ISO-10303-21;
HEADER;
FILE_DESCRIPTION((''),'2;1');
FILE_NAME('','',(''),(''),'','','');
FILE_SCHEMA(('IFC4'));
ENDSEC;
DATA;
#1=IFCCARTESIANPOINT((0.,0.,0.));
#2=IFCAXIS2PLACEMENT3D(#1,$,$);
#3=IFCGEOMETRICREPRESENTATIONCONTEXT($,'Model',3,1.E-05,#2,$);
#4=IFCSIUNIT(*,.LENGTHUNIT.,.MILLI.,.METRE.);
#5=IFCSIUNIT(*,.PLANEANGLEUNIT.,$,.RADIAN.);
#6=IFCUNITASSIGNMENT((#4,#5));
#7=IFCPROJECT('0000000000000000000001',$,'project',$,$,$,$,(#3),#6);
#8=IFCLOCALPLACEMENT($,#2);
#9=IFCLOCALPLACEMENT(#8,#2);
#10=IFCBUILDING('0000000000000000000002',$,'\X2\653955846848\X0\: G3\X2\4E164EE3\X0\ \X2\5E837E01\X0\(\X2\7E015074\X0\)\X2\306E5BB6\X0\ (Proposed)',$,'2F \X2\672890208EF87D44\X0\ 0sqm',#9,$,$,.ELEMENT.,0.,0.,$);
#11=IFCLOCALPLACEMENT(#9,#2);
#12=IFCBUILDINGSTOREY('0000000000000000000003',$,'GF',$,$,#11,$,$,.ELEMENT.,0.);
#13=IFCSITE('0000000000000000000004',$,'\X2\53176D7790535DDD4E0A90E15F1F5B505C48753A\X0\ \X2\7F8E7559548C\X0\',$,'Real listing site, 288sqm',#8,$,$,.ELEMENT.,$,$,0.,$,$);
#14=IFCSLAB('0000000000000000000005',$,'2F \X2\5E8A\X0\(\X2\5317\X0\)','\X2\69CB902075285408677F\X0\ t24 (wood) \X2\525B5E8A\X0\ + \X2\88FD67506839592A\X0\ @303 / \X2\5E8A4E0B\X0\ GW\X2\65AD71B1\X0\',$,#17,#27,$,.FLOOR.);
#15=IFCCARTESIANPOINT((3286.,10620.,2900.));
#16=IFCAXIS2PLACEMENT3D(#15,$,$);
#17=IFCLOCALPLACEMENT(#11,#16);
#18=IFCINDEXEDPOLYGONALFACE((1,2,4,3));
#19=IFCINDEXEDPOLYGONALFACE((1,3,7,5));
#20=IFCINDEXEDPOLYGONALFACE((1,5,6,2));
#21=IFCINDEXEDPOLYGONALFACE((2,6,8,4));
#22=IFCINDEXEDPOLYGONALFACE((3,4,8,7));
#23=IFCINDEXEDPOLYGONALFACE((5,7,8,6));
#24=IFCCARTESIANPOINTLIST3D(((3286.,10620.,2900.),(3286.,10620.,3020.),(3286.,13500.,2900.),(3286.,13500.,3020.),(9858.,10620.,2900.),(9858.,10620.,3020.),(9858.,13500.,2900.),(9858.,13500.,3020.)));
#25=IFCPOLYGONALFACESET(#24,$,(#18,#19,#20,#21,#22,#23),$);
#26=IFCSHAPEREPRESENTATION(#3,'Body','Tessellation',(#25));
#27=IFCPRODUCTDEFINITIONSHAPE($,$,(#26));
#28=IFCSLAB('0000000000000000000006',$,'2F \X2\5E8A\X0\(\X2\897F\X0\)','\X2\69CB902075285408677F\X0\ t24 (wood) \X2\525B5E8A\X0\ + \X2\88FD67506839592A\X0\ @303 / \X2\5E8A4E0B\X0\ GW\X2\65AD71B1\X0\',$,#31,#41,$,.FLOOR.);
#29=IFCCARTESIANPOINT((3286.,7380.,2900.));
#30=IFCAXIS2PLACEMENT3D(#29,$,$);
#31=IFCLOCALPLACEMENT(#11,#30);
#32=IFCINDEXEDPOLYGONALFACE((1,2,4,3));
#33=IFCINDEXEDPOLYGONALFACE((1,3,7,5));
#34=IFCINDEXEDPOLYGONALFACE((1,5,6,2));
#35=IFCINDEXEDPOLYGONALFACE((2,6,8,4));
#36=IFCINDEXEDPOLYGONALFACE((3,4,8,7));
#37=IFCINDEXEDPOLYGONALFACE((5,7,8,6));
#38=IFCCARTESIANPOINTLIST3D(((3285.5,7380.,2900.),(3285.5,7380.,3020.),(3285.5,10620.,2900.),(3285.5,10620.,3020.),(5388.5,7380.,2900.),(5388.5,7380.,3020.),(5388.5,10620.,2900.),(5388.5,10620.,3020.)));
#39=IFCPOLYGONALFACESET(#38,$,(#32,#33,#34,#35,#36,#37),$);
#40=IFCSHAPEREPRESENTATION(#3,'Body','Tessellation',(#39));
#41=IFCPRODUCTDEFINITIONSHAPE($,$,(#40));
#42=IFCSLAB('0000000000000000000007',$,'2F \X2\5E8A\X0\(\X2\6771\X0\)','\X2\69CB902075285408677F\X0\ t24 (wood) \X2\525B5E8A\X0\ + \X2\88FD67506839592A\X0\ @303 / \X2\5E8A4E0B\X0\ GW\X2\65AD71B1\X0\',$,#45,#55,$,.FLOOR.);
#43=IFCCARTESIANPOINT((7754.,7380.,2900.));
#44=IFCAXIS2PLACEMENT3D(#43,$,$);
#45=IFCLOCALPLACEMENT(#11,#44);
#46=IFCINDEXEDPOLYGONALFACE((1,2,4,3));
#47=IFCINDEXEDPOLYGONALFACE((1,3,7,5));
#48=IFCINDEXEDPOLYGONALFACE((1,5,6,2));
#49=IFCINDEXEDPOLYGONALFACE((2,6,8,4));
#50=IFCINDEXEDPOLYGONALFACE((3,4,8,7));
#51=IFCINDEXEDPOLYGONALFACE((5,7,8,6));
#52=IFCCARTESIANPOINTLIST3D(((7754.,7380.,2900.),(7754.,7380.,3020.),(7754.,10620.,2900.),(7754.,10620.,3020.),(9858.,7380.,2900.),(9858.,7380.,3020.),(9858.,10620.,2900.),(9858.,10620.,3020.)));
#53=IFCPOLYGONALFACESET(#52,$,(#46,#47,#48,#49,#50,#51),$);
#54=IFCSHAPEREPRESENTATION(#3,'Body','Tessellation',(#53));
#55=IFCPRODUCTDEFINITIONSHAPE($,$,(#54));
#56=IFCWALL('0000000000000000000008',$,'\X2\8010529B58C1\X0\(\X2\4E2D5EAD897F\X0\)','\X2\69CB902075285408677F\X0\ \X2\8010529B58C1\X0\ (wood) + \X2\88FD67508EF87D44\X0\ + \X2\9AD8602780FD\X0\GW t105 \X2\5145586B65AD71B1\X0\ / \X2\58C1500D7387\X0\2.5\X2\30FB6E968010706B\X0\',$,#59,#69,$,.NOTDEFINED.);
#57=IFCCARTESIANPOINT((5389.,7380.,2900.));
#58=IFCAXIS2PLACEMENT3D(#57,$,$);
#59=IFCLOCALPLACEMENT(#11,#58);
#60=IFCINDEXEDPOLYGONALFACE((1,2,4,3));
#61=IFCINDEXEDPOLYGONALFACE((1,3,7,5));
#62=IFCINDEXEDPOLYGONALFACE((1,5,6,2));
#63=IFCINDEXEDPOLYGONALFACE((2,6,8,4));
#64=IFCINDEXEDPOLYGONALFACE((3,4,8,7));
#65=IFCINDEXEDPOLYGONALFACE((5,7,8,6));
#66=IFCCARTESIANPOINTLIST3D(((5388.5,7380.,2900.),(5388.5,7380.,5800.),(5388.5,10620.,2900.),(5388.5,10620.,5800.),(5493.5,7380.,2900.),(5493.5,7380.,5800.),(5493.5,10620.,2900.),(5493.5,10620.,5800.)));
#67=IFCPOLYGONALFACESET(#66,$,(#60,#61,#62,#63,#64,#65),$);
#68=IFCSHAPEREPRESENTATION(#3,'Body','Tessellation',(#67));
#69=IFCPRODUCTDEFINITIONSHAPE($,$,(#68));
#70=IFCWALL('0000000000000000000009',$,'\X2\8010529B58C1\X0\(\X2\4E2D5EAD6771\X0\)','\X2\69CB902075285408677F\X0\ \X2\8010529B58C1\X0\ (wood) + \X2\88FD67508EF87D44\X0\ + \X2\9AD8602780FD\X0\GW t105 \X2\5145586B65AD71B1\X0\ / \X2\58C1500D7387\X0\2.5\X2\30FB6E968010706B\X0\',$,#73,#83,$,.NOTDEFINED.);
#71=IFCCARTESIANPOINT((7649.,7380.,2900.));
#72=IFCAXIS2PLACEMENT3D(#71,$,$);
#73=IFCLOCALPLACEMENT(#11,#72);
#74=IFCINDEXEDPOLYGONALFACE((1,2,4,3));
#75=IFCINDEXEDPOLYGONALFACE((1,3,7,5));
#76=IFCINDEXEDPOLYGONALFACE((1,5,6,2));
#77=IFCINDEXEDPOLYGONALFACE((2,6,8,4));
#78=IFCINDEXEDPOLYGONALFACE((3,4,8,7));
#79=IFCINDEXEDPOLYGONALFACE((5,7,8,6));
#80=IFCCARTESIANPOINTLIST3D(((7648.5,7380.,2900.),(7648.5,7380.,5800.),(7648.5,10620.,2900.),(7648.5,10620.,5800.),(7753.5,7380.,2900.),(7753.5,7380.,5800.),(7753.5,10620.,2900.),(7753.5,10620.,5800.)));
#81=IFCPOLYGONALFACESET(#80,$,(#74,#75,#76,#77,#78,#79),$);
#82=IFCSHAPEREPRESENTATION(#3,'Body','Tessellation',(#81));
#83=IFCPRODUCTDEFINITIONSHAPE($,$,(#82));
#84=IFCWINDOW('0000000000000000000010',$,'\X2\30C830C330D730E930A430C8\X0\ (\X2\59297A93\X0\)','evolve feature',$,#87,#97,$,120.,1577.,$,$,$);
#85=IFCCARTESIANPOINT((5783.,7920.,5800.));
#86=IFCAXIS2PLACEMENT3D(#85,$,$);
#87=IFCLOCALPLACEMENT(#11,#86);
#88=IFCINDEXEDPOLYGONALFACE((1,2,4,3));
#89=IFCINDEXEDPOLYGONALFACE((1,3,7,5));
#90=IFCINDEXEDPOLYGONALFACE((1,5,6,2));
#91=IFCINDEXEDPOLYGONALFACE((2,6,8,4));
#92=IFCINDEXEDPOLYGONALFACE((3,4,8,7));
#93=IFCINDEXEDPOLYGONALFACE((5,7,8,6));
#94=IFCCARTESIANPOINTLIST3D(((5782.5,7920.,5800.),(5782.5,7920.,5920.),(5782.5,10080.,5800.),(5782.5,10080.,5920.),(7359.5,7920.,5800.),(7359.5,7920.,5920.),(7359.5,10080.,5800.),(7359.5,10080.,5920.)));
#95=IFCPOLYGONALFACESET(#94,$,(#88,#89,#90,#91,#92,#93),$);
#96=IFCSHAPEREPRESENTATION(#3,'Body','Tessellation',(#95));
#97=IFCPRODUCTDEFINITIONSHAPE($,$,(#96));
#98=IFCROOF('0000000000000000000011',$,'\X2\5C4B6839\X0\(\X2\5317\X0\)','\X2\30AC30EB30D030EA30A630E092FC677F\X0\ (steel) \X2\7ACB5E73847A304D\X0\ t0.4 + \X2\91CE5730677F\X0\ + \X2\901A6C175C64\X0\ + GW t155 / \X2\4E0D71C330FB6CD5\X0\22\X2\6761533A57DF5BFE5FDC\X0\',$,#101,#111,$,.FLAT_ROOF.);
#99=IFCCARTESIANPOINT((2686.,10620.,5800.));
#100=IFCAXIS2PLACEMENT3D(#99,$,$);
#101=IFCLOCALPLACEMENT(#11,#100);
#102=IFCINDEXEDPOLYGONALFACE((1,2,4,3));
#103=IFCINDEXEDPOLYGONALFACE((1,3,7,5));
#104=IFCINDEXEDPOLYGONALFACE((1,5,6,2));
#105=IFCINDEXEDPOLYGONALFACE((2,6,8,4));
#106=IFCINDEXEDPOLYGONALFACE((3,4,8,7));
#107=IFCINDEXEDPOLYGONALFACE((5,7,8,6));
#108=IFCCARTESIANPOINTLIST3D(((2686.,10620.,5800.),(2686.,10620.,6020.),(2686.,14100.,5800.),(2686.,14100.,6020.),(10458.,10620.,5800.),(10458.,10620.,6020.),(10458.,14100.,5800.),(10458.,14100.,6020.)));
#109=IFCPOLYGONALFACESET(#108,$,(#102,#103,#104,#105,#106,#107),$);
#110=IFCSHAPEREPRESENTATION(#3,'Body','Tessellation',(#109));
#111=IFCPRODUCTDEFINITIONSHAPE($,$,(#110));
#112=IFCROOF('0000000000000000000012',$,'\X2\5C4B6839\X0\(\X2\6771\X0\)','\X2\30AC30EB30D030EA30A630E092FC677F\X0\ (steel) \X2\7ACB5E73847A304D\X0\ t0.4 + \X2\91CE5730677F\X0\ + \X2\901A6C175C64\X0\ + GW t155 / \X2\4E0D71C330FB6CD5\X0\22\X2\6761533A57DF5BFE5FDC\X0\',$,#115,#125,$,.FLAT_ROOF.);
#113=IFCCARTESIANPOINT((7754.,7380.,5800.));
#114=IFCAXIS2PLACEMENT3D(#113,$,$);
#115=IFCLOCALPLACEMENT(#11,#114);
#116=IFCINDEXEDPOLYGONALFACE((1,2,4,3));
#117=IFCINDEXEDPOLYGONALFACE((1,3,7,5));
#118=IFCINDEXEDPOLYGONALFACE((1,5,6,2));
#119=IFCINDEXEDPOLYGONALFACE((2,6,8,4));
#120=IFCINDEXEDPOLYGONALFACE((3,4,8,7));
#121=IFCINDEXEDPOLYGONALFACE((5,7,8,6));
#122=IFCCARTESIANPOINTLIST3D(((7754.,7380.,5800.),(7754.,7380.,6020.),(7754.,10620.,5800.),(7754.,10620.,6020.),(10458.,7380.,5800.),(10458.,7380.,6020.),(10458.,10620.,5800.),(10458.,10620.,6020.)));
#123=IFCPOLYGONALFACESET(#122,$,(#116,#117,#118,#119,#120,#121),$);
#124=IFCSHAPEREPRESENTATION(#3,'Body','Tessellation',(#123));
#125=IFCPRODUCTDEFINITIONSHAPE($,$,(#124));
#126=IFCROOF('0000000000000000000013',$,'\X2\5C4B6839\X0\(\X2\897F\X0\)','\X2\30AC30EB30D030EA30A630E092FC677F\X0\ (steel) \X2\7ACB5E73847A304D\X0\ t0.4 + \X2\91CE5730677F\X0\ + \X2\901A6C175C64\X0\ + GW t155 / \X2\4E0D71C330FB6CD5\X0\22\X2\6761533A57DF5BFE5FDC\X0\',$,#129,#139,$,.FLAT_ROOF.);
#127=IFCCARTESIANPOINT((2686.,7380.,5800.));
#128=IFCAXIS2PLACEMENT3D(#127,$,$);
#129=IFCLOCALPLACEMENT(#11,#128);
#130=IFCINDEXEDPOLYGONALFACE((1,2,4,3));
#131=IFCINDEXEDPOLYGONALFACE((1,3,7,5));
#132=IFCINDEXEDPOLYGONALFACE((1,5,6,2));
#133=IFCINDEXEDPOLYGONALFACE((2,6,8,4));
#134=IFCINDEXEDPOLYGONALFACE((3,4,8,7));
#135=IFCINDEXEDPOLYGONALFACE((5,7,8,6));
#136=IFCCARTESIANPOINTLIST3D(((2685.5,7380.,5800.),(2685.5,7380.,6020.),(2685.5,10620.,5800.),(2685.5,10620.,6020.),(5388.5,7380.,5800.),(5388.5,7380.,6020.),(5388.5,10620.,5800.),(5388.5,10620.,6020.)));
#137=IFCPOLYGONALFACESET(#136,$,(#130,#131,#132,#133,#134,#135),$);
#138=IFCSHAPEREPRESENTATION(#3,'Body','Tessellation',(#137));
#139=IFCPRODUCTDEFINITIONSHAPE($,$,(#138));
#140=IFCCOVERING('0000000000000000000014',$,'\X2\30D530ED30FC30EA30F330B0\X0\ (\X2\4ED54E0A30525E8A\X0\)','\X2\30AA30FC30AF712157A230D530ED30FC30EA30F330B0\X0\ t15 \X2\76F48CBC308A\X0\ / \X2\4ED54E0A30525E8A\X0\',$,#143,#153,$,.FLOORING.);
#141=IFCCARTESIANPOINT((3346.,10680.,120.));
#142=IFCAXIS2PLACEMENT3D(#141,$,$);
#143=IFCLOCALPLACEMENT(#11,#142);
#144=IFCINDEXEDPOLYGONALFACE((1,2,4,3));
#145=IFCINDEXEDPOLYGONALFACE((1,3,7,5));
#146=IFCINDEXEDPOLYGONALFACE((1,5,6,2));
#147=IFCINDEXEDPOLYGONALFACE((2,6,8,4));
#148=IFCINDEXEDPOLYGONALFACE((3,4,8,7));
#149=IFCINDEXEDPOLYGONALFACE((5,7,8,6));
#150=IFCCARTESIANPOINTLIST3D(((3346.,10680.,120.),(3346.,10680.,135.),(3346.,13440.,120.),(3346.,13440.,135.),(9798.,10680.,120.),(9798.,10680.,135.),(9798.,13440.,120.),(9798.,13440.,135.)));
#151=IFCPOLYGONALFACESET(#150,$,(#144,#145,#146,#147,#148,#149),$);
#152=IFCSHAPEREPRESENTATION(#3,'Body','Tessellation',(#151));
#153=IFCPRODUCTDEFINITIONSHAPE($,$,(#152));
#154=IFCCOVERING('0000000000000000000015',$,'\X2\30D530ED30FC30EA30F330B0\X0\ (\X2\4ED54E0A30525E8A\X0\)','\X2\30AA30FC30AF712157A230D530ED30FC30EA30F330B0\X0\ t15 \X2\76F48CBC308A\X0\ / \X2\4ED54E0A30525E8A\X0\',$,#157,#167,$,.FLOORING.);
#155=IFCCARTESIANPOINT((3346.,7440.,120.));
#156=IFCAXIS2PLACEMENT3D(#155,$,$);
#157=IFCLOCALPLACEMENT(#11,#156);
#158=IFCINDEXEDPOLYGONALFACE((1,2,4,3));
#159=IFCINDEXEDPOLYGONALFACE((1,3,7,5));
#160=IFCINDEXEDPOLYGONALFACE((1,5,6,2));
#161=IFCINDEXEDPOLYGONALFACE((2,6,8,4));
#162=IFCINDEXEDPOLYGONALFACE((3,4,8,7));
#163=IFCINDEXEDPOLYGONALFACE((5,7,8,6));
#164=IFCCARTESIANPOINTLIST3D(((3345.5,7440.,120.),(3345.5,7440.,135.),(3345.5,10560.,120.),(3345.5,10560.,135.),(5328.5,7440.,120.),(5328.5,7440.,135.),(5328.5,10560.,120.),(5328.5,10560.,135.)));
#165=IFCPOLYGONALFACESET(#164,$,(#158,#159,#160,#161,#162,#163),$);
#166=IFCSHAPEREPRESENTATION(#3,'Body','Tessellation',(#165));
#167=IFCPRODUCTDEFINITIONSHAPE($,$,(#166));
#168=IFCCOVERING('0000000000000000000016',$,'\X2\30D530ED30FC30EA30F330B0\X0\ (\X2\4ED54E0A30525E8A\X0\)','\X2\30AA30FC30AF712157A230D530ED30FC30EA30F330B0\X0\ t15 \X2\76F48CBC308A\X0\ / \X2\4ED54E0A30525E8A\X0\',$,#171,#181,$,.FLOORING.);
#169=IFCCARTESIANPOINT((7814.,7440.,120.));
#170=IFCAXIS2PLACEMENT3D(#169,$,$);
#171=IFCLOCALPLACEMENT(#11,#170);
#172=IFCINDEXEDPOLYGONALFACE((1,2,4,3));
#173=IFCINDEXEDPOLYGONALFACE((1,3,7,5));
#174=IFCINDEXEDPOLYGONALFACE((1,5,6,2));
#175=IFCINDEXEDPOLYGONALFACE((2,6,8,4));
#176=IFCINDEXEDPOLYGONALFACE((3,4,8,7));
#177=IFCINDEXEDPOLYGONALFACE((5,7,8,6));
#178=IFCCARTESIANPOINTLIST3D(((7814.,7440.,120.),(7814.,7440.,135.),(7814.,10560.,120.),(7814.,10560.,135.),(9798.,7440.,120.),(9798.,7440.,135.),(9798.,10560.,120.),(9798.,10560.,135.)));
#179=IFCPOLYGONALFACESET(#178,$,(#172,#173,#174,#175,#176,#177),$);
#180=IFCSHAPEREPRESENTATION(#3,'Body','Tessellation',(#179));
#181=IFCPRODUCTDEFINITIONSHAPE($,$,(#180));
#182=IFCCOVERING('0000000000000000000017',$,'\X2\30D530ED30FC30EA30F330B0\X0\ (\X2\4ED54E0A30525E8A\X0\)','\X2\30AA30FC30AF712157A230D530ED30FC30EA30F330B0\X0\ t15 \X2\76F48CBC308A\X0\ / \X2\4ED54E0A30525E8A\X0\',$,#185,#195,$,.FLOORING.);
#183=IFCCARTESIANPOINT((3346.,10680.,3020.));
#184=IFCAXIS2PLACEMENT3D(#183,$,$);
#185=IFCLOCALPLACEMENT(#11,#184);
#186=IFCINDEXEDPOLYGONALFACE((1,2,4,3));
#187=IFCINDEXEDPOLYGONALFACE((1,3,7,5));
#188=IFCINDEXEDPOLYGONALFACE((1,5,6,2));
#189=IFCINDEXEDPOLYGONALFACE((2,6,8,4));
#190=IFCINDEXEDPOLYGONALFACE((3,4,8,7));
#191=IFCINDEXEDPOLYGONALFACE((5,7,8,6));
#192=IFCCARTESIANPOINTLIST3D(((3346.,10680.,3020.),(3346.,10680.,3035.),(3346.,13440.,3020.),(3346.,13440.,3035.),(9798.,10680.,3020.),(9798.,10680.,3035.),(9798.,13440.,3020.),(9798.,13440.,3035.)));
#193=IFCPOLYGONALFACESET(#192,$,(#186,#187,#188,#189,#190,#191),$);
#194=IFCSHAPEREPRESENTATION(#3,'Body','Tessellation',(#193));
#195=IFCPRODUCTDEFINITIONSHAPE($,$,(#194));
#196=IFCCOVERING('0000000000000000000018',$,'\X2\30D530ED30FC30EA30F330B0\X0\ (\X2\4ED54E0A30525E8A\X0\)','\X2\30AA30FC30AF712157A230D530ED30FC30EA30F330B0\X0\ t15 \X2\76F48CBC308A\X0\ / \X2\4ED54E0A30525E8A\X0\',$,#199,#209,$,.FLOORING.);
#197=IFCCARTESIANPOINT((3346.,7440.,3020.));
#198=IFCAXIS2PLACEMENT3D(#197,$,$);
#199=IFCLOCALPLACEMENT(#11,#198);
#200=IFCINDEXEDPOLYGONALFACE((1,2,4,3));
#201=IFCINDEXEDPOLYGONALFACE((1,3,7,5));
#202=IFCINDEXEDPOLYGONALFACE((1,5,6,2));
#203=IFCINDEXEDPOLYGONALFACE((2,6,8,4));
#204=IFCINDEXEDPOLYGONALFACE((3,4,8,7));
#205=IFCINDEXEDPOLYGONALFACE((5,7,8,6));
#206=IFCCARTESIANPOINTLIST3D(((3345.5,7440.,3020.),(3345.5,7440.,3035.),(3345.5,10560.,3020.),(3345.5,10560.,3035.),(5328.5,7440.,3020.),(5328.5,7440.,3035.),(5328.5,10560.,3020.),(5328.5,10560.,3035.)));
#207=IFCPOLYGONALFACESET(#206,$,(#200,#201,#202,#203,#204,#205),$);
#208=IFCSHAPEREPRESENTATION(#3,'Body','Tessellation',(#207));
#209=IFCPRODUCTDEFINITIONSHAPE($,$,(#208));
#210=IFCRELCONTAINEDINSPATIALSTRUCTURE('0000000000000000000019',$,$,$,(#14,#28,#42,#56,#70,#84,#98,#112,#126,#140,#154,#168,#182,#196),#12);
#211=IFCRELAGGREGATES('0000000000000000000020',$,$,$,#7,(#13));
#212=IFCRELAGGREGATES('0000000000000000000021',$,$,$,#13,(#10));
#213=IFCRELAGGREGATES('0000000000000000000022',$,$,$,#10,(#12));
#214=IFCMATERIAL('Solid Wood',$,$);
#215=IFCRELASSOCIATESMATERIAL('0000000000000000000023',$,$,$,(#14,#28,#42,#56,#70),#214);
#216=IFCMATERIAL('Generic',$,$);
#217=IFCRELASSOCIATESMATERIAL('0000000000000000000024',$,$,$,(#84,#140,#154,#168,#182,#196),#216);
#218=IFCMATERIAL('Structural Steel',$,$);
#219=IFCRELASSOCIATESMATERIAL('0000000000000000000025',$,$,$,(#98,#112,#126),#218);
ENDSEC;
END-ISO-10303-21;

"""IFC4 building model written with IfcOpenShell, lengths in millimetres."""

from ifc_helpers import new_model, si_unit, frame, frame_2d, origin, place, context, project, spatial, rectangle, extrude, material, element, save


model = new_model("IFC4")

# Units and contexts
model_context = context("Model", 3, precision=1e-05, world=origin())
ifc_project = project(units=[si_unit("LENGTHUNIT", "METRE", prefix="MILLI"), si_unit("PLANEANGLEUNIT", "RADIAN")], contexts=[model_context])

# Site, building, storey
site_placement = place(None, origin())
site = spatial("IfcSite", under=ifc_project, at=site_placement, Name="北海道川上郡弟子屈町 美留和", ObjectType="Real listing site, 288sqm", CompositionType="ELEMENT", RefElevation=0.0)
building_placement = place(site_placement, origin())
building = spatial("IfcBuilding", under=site, at=building_placement, Name="改善案: G3世代 広縁(縁側)の家 (Proposed)", ObjectType="2F 木造軸組 0sqm", CompositionType="ELEMENT", ElevationOfRefHeight=0.0, ElevationOfTerrain=0.0)
storey_placement = place(building_placement, origin())
storey = spatial("IfcBuildingStorey", under=building, at=storey_placement, Name="GF", CompositionType="ELEMENT", Elevation=0.0)

# Slabs
ifc_material_1 = material(Name="Solid Wood")
slab_1_placement = place(storey_placement, frame((3286.0, 10620.0, 2900.0)))
element("IfcSlab", 1, at=slab_1_placement, inside=storey, material=ifc_material_1, Name="2F 床(北)", Description="構造用合板 t24 (wood) 剛床 + 製材根太 @303 / 床下 GW断熱", PredefinedType="FLOOR", context=model_context, shape_type="SweptSolid", body=[
    extrude(rectangle(XDim=6572.0, YDim=2880.0, at=frame_2d((3286.0, 1440.0))), frame((3286.0, 10620.0, 2900.0)), (0.0, 0.0, 1.0), 120.0),
])
slab_2_placement = place(storey_placement, frame((3286.0, 7380.0, 2900.0)))
element("IfcSlab", 2, at=slab_2_placement, inside=storey, material=ifc_material_1, Name="2F 床(西)", Description="構造用合板 t24 (wood) 剛床 + 製材根太 @303 / 床下 GW断熱", PredefinedType="FLOOR", context=model_context, shape_type="SweptSolid", body=[
    extrude(rectangle(XDim=2103.0, YDim=3240.0, at=frame_2d((1051.0, 1620.0))), frame((3286.0, 7380.0, 2900.0)), (0.0, 0.0, 1.0), 120.0),
])
slab_3_placement = place(storey_placement, frame((7754.0, 7380.0, 2900.0)))
element("IfcSlab", 3, at=slab_3_placement, inside=storey, material=ifc_material_1, Name="2F 床(東)", Description="構造用合板 t24 (wood) 剛床 + 製材根太 @303 / 床下 GW断熱", PredefinedType="FLOOR", context=model_context, shape_type="SweptSolid", body=[
    extrude(rectangle(XDim=2104.0, YDim=3240.0, at=frame_2d((1052.0, 1620.0))), frame((7754.0, 7380.0, 2900.0)), (0.0, 0.0, 1.0), 120.0),
])

# Walls
wall_1_placement = place(storey_placement, frame((5389.0, 7380.0, 2900.0)))
element("IfcWall", 4, at=wall_1_placement, inside=storey, material=ifc_material_1, Name="耐力壁(中庭西)", Description="構造用合板 耐力壁 (wood) + 製材軸組 + 高性能GW t105 充填断熱 / 壁倍率2.5・準耐火", PredefinedType="NOTDEFINED", context=model_context, shape_type="SweptSolid", body=[
    extrude(rectangle(XDim=105.0, YDim=3240.0, at=frame_2d((52.0, 1620.0))), frame((5389.0, 7380.0, 2900.0)), (0.0, 0.0, 1.0), 2900.0),
])
wall_2_placement = place(storey_placement, frame((7649.0, 7380.0, 2900.0)))
element("IfcWall", 5, at=wall_2_placement, inside=storey, material=ifc_material_1, Name="耐力壁(中庭東)", Description="構造用合板 耐力壁 (wood) + 製材軸組 + 高性能GW t105 充填断熱 / 壁倍率2.5・準耐火", PredefinedType="NOTDEFINED", context=model_context, shape_type="SweptSolid", body=[
    extrude(rectangle(XDim=105.0, YDim=3240.0, at=frame_2d((52.0, 1620.0))), frame((7649.0, 7380.0, 2900.0)), (0.0, 0.0, 1.0), 2900.0),
])

# Window
ifc_material_2 = material(Name="Generic")
window_1_placement = place(storey_placement, frame((5783.0, 7920.0, 5800.0)))
element("IfcWindow", 6, at=window_1_placement, inside=storey, material=ifc_material_2, Name="トップライト (天窓)", Description="evolve feature", OverallHeight=120.0, OverallWidth=1577.0, context=model_context, shape_type="SweptSolid", body=[
    extrude(rectangle(XDim=1577.0, YDim=2160.0, at=frame_2d((788.0, 1080.0))), frame((5783.0, 7920.0, 5800.0)), (0.0, 0.0, 1.0), 120.0),
])

# Roofs
ifc_material_3 = material(Name="Structural Steel")
roof_1_placement = place(storey_placement, frame((2686.0, 10620.0, 5800.0)))
element("IfcRoof", 7, at=roof_1_placement, inside=storey, material=ifc_material_3, Name="屋根(北)", Description="ガルバリウム鋼板 (steel) 立平葺き t0.4 + 野地板 + 通気層 + GW t155 / 不燃・法22条区域対応", PredefinedType="FLAT_ROOF", context=model_context, shape_type="SweptSolid", body=[
    extrude(rectangle(XDim=7772.0, YDim=3480.0, at=frame_2d((3886.0, 1740.0))), frame((2686.0, 10620.0, 5800.0)), (0.0, 0.0, 1.0), 220.0),
])
roof_2_placement = place(storey_placement, frame((7754.0, 7380.0, 5800.0)))
element("IfcRoof", 8, at=roof_2_placement, inside=storey, material=ifc_material_3, Name="屋根(東)", Description="ガルバリウム鋼板 (steel) 立平葺き t0.4 + 野地板 + 通気層 + GW t155 / 不燃・法22条区域対応", PredefinedType="FLAT_ROOF", context=model_context, shape_type="SweptSolid", body=[
    extrude(rectangle(XDim=2704.0, YDim=3240.0, at=frame_2d((1352.0, 1620.0))), frame((7754.0, 7380.0, 5800.0)), (0.0, 0.0, 1.0), 220.0),
])
roof_3_placement = place(storey_placement, frame((2686.0, 7380.0, 5800.0)))
element("IfcRoof", 9, at=roof_3_placement, inside=storey, material=ifc_material_3, Name="屋根(西)", Description="ガルバリウム鋼板 (steel) 立平葺き t0.4 + 野地板 + 通気層 + GW t155 / 不燃・法22条区域対応", PredefinedType="FLAT_ROOF", context=model_context, shape_type="SweptSolid", body=[
    extrude(rectangle(XDim=2703.0, YDim=3240.0, at=frame_2d((1351.0, 1620.0))), frame((2686.0, 7380.0, 5800.0)), (0.0, 0.0, 1.0), 220.0),
])

# Coverings
covering_1_placement = place(storey_placement, frame((3346.0, 10680.0, 120.0)))
element("IfcCovering", 10, at=covering_1_placement, inside=storey, material=ifc_material_2, Name="フローリング (仕上げ床)", Description="オーク無垢フローリング t15 直貼り / 仕上げ床", PredefinedType="FLOORING", context=model_context, shape_type="SweptSolid", body=[
    extrude(rectangle(XDim=6452.0, YDim=2760.0, at=frame_2d((3226.0, 1380.0))), frame((3346.0, 10680.0, 120.0)), (0.0, 0.0, 1.0), 15.0),
])
covering_2_placement = place(storey_placement, frame((3346.0, 7440.0, 120.0)))
element("IfcCovering", 11, at=covering_2_placement, inside=storey, material=ifc_material_2, Name="フローリング (仕上げ床)", Description="オーク無垢フローリング t15 直貼り / 仕上げ床", PredefinedType="FLOORING", context=model_context, shape_type="SweptSolid", body=[
    extrude(rectangle(XDim=1983.0, YDim=3120.0, at=frame_2d((991.0, 1560.0))), frame((3346.0, 7440.0, 120.0)), (0.0, 0.0, 1.0), 15.0),
])
covering_3_placement = place(storey_placement, frame((7814.0, 7440.0, 120.0)))
element("IfcCovering", 12, at=covering_3_placement, inside=storey, material=ifc_material_2, Name="フローリング (仕上げ床)", Description="オーク無垢フローリング t15 直貼り / 仕上げ床", PredefinedType="FLOORING", context=model_context, shape_type="SweptSolid", body=[
    extrude(rectangle(XDim=1984.0, YDim=3120.0, at=frame_2d((992.0, 1560.0))), frame((7814.0, 7440.0, 120.0)), (0.0, 0.0, 1.0), 15.0),
])
covering_4_placement = place(storey_placement, frame((3346.0, 10680.0, 3020.0)))
element("IfcCovering", 13, at=covering_4_placement, inside=storey, material=ifc_material_2, Name="フローリング (仕上げ床)", Description="オーク無垢フローリング t15 直貼り / 仕上げ床", PredefinedType="FLOORING", context=model_context, shape_type="SweptSolid", body=[
    extrude(rectangle(XDim=6452.0, YDim=2760.0, at=frame_2d((3226.0, 1380.0))), frame((3346.0, 10680.0, 3020.0)), (0.0, 0.0, 1.0), 15.0),
])
covering_5_placement = place(storey_placement, frame((3346.0, 7440.0, 3020.0)))
element("IfcCovering", 14, at=covering_5_placement, inside=storey, material=ifc_material_2, Name="フローリング (仕上げ床)", Description="オーク無垢フローリング t15 直貼り / 仕上げ床", PredefinedType="FLOORING", context=model_context, shape_type="SweptSolid", body=[
    extrude(rectangle(XDim=1983.0, YDim=3120.0, at=frame_2d((991.0, 1560.0))), frame((3346.0, 7440.0, 3020.0)), (0.0, 0.0, 1.0), 15.0),
])

save(model, "model.ifc")
